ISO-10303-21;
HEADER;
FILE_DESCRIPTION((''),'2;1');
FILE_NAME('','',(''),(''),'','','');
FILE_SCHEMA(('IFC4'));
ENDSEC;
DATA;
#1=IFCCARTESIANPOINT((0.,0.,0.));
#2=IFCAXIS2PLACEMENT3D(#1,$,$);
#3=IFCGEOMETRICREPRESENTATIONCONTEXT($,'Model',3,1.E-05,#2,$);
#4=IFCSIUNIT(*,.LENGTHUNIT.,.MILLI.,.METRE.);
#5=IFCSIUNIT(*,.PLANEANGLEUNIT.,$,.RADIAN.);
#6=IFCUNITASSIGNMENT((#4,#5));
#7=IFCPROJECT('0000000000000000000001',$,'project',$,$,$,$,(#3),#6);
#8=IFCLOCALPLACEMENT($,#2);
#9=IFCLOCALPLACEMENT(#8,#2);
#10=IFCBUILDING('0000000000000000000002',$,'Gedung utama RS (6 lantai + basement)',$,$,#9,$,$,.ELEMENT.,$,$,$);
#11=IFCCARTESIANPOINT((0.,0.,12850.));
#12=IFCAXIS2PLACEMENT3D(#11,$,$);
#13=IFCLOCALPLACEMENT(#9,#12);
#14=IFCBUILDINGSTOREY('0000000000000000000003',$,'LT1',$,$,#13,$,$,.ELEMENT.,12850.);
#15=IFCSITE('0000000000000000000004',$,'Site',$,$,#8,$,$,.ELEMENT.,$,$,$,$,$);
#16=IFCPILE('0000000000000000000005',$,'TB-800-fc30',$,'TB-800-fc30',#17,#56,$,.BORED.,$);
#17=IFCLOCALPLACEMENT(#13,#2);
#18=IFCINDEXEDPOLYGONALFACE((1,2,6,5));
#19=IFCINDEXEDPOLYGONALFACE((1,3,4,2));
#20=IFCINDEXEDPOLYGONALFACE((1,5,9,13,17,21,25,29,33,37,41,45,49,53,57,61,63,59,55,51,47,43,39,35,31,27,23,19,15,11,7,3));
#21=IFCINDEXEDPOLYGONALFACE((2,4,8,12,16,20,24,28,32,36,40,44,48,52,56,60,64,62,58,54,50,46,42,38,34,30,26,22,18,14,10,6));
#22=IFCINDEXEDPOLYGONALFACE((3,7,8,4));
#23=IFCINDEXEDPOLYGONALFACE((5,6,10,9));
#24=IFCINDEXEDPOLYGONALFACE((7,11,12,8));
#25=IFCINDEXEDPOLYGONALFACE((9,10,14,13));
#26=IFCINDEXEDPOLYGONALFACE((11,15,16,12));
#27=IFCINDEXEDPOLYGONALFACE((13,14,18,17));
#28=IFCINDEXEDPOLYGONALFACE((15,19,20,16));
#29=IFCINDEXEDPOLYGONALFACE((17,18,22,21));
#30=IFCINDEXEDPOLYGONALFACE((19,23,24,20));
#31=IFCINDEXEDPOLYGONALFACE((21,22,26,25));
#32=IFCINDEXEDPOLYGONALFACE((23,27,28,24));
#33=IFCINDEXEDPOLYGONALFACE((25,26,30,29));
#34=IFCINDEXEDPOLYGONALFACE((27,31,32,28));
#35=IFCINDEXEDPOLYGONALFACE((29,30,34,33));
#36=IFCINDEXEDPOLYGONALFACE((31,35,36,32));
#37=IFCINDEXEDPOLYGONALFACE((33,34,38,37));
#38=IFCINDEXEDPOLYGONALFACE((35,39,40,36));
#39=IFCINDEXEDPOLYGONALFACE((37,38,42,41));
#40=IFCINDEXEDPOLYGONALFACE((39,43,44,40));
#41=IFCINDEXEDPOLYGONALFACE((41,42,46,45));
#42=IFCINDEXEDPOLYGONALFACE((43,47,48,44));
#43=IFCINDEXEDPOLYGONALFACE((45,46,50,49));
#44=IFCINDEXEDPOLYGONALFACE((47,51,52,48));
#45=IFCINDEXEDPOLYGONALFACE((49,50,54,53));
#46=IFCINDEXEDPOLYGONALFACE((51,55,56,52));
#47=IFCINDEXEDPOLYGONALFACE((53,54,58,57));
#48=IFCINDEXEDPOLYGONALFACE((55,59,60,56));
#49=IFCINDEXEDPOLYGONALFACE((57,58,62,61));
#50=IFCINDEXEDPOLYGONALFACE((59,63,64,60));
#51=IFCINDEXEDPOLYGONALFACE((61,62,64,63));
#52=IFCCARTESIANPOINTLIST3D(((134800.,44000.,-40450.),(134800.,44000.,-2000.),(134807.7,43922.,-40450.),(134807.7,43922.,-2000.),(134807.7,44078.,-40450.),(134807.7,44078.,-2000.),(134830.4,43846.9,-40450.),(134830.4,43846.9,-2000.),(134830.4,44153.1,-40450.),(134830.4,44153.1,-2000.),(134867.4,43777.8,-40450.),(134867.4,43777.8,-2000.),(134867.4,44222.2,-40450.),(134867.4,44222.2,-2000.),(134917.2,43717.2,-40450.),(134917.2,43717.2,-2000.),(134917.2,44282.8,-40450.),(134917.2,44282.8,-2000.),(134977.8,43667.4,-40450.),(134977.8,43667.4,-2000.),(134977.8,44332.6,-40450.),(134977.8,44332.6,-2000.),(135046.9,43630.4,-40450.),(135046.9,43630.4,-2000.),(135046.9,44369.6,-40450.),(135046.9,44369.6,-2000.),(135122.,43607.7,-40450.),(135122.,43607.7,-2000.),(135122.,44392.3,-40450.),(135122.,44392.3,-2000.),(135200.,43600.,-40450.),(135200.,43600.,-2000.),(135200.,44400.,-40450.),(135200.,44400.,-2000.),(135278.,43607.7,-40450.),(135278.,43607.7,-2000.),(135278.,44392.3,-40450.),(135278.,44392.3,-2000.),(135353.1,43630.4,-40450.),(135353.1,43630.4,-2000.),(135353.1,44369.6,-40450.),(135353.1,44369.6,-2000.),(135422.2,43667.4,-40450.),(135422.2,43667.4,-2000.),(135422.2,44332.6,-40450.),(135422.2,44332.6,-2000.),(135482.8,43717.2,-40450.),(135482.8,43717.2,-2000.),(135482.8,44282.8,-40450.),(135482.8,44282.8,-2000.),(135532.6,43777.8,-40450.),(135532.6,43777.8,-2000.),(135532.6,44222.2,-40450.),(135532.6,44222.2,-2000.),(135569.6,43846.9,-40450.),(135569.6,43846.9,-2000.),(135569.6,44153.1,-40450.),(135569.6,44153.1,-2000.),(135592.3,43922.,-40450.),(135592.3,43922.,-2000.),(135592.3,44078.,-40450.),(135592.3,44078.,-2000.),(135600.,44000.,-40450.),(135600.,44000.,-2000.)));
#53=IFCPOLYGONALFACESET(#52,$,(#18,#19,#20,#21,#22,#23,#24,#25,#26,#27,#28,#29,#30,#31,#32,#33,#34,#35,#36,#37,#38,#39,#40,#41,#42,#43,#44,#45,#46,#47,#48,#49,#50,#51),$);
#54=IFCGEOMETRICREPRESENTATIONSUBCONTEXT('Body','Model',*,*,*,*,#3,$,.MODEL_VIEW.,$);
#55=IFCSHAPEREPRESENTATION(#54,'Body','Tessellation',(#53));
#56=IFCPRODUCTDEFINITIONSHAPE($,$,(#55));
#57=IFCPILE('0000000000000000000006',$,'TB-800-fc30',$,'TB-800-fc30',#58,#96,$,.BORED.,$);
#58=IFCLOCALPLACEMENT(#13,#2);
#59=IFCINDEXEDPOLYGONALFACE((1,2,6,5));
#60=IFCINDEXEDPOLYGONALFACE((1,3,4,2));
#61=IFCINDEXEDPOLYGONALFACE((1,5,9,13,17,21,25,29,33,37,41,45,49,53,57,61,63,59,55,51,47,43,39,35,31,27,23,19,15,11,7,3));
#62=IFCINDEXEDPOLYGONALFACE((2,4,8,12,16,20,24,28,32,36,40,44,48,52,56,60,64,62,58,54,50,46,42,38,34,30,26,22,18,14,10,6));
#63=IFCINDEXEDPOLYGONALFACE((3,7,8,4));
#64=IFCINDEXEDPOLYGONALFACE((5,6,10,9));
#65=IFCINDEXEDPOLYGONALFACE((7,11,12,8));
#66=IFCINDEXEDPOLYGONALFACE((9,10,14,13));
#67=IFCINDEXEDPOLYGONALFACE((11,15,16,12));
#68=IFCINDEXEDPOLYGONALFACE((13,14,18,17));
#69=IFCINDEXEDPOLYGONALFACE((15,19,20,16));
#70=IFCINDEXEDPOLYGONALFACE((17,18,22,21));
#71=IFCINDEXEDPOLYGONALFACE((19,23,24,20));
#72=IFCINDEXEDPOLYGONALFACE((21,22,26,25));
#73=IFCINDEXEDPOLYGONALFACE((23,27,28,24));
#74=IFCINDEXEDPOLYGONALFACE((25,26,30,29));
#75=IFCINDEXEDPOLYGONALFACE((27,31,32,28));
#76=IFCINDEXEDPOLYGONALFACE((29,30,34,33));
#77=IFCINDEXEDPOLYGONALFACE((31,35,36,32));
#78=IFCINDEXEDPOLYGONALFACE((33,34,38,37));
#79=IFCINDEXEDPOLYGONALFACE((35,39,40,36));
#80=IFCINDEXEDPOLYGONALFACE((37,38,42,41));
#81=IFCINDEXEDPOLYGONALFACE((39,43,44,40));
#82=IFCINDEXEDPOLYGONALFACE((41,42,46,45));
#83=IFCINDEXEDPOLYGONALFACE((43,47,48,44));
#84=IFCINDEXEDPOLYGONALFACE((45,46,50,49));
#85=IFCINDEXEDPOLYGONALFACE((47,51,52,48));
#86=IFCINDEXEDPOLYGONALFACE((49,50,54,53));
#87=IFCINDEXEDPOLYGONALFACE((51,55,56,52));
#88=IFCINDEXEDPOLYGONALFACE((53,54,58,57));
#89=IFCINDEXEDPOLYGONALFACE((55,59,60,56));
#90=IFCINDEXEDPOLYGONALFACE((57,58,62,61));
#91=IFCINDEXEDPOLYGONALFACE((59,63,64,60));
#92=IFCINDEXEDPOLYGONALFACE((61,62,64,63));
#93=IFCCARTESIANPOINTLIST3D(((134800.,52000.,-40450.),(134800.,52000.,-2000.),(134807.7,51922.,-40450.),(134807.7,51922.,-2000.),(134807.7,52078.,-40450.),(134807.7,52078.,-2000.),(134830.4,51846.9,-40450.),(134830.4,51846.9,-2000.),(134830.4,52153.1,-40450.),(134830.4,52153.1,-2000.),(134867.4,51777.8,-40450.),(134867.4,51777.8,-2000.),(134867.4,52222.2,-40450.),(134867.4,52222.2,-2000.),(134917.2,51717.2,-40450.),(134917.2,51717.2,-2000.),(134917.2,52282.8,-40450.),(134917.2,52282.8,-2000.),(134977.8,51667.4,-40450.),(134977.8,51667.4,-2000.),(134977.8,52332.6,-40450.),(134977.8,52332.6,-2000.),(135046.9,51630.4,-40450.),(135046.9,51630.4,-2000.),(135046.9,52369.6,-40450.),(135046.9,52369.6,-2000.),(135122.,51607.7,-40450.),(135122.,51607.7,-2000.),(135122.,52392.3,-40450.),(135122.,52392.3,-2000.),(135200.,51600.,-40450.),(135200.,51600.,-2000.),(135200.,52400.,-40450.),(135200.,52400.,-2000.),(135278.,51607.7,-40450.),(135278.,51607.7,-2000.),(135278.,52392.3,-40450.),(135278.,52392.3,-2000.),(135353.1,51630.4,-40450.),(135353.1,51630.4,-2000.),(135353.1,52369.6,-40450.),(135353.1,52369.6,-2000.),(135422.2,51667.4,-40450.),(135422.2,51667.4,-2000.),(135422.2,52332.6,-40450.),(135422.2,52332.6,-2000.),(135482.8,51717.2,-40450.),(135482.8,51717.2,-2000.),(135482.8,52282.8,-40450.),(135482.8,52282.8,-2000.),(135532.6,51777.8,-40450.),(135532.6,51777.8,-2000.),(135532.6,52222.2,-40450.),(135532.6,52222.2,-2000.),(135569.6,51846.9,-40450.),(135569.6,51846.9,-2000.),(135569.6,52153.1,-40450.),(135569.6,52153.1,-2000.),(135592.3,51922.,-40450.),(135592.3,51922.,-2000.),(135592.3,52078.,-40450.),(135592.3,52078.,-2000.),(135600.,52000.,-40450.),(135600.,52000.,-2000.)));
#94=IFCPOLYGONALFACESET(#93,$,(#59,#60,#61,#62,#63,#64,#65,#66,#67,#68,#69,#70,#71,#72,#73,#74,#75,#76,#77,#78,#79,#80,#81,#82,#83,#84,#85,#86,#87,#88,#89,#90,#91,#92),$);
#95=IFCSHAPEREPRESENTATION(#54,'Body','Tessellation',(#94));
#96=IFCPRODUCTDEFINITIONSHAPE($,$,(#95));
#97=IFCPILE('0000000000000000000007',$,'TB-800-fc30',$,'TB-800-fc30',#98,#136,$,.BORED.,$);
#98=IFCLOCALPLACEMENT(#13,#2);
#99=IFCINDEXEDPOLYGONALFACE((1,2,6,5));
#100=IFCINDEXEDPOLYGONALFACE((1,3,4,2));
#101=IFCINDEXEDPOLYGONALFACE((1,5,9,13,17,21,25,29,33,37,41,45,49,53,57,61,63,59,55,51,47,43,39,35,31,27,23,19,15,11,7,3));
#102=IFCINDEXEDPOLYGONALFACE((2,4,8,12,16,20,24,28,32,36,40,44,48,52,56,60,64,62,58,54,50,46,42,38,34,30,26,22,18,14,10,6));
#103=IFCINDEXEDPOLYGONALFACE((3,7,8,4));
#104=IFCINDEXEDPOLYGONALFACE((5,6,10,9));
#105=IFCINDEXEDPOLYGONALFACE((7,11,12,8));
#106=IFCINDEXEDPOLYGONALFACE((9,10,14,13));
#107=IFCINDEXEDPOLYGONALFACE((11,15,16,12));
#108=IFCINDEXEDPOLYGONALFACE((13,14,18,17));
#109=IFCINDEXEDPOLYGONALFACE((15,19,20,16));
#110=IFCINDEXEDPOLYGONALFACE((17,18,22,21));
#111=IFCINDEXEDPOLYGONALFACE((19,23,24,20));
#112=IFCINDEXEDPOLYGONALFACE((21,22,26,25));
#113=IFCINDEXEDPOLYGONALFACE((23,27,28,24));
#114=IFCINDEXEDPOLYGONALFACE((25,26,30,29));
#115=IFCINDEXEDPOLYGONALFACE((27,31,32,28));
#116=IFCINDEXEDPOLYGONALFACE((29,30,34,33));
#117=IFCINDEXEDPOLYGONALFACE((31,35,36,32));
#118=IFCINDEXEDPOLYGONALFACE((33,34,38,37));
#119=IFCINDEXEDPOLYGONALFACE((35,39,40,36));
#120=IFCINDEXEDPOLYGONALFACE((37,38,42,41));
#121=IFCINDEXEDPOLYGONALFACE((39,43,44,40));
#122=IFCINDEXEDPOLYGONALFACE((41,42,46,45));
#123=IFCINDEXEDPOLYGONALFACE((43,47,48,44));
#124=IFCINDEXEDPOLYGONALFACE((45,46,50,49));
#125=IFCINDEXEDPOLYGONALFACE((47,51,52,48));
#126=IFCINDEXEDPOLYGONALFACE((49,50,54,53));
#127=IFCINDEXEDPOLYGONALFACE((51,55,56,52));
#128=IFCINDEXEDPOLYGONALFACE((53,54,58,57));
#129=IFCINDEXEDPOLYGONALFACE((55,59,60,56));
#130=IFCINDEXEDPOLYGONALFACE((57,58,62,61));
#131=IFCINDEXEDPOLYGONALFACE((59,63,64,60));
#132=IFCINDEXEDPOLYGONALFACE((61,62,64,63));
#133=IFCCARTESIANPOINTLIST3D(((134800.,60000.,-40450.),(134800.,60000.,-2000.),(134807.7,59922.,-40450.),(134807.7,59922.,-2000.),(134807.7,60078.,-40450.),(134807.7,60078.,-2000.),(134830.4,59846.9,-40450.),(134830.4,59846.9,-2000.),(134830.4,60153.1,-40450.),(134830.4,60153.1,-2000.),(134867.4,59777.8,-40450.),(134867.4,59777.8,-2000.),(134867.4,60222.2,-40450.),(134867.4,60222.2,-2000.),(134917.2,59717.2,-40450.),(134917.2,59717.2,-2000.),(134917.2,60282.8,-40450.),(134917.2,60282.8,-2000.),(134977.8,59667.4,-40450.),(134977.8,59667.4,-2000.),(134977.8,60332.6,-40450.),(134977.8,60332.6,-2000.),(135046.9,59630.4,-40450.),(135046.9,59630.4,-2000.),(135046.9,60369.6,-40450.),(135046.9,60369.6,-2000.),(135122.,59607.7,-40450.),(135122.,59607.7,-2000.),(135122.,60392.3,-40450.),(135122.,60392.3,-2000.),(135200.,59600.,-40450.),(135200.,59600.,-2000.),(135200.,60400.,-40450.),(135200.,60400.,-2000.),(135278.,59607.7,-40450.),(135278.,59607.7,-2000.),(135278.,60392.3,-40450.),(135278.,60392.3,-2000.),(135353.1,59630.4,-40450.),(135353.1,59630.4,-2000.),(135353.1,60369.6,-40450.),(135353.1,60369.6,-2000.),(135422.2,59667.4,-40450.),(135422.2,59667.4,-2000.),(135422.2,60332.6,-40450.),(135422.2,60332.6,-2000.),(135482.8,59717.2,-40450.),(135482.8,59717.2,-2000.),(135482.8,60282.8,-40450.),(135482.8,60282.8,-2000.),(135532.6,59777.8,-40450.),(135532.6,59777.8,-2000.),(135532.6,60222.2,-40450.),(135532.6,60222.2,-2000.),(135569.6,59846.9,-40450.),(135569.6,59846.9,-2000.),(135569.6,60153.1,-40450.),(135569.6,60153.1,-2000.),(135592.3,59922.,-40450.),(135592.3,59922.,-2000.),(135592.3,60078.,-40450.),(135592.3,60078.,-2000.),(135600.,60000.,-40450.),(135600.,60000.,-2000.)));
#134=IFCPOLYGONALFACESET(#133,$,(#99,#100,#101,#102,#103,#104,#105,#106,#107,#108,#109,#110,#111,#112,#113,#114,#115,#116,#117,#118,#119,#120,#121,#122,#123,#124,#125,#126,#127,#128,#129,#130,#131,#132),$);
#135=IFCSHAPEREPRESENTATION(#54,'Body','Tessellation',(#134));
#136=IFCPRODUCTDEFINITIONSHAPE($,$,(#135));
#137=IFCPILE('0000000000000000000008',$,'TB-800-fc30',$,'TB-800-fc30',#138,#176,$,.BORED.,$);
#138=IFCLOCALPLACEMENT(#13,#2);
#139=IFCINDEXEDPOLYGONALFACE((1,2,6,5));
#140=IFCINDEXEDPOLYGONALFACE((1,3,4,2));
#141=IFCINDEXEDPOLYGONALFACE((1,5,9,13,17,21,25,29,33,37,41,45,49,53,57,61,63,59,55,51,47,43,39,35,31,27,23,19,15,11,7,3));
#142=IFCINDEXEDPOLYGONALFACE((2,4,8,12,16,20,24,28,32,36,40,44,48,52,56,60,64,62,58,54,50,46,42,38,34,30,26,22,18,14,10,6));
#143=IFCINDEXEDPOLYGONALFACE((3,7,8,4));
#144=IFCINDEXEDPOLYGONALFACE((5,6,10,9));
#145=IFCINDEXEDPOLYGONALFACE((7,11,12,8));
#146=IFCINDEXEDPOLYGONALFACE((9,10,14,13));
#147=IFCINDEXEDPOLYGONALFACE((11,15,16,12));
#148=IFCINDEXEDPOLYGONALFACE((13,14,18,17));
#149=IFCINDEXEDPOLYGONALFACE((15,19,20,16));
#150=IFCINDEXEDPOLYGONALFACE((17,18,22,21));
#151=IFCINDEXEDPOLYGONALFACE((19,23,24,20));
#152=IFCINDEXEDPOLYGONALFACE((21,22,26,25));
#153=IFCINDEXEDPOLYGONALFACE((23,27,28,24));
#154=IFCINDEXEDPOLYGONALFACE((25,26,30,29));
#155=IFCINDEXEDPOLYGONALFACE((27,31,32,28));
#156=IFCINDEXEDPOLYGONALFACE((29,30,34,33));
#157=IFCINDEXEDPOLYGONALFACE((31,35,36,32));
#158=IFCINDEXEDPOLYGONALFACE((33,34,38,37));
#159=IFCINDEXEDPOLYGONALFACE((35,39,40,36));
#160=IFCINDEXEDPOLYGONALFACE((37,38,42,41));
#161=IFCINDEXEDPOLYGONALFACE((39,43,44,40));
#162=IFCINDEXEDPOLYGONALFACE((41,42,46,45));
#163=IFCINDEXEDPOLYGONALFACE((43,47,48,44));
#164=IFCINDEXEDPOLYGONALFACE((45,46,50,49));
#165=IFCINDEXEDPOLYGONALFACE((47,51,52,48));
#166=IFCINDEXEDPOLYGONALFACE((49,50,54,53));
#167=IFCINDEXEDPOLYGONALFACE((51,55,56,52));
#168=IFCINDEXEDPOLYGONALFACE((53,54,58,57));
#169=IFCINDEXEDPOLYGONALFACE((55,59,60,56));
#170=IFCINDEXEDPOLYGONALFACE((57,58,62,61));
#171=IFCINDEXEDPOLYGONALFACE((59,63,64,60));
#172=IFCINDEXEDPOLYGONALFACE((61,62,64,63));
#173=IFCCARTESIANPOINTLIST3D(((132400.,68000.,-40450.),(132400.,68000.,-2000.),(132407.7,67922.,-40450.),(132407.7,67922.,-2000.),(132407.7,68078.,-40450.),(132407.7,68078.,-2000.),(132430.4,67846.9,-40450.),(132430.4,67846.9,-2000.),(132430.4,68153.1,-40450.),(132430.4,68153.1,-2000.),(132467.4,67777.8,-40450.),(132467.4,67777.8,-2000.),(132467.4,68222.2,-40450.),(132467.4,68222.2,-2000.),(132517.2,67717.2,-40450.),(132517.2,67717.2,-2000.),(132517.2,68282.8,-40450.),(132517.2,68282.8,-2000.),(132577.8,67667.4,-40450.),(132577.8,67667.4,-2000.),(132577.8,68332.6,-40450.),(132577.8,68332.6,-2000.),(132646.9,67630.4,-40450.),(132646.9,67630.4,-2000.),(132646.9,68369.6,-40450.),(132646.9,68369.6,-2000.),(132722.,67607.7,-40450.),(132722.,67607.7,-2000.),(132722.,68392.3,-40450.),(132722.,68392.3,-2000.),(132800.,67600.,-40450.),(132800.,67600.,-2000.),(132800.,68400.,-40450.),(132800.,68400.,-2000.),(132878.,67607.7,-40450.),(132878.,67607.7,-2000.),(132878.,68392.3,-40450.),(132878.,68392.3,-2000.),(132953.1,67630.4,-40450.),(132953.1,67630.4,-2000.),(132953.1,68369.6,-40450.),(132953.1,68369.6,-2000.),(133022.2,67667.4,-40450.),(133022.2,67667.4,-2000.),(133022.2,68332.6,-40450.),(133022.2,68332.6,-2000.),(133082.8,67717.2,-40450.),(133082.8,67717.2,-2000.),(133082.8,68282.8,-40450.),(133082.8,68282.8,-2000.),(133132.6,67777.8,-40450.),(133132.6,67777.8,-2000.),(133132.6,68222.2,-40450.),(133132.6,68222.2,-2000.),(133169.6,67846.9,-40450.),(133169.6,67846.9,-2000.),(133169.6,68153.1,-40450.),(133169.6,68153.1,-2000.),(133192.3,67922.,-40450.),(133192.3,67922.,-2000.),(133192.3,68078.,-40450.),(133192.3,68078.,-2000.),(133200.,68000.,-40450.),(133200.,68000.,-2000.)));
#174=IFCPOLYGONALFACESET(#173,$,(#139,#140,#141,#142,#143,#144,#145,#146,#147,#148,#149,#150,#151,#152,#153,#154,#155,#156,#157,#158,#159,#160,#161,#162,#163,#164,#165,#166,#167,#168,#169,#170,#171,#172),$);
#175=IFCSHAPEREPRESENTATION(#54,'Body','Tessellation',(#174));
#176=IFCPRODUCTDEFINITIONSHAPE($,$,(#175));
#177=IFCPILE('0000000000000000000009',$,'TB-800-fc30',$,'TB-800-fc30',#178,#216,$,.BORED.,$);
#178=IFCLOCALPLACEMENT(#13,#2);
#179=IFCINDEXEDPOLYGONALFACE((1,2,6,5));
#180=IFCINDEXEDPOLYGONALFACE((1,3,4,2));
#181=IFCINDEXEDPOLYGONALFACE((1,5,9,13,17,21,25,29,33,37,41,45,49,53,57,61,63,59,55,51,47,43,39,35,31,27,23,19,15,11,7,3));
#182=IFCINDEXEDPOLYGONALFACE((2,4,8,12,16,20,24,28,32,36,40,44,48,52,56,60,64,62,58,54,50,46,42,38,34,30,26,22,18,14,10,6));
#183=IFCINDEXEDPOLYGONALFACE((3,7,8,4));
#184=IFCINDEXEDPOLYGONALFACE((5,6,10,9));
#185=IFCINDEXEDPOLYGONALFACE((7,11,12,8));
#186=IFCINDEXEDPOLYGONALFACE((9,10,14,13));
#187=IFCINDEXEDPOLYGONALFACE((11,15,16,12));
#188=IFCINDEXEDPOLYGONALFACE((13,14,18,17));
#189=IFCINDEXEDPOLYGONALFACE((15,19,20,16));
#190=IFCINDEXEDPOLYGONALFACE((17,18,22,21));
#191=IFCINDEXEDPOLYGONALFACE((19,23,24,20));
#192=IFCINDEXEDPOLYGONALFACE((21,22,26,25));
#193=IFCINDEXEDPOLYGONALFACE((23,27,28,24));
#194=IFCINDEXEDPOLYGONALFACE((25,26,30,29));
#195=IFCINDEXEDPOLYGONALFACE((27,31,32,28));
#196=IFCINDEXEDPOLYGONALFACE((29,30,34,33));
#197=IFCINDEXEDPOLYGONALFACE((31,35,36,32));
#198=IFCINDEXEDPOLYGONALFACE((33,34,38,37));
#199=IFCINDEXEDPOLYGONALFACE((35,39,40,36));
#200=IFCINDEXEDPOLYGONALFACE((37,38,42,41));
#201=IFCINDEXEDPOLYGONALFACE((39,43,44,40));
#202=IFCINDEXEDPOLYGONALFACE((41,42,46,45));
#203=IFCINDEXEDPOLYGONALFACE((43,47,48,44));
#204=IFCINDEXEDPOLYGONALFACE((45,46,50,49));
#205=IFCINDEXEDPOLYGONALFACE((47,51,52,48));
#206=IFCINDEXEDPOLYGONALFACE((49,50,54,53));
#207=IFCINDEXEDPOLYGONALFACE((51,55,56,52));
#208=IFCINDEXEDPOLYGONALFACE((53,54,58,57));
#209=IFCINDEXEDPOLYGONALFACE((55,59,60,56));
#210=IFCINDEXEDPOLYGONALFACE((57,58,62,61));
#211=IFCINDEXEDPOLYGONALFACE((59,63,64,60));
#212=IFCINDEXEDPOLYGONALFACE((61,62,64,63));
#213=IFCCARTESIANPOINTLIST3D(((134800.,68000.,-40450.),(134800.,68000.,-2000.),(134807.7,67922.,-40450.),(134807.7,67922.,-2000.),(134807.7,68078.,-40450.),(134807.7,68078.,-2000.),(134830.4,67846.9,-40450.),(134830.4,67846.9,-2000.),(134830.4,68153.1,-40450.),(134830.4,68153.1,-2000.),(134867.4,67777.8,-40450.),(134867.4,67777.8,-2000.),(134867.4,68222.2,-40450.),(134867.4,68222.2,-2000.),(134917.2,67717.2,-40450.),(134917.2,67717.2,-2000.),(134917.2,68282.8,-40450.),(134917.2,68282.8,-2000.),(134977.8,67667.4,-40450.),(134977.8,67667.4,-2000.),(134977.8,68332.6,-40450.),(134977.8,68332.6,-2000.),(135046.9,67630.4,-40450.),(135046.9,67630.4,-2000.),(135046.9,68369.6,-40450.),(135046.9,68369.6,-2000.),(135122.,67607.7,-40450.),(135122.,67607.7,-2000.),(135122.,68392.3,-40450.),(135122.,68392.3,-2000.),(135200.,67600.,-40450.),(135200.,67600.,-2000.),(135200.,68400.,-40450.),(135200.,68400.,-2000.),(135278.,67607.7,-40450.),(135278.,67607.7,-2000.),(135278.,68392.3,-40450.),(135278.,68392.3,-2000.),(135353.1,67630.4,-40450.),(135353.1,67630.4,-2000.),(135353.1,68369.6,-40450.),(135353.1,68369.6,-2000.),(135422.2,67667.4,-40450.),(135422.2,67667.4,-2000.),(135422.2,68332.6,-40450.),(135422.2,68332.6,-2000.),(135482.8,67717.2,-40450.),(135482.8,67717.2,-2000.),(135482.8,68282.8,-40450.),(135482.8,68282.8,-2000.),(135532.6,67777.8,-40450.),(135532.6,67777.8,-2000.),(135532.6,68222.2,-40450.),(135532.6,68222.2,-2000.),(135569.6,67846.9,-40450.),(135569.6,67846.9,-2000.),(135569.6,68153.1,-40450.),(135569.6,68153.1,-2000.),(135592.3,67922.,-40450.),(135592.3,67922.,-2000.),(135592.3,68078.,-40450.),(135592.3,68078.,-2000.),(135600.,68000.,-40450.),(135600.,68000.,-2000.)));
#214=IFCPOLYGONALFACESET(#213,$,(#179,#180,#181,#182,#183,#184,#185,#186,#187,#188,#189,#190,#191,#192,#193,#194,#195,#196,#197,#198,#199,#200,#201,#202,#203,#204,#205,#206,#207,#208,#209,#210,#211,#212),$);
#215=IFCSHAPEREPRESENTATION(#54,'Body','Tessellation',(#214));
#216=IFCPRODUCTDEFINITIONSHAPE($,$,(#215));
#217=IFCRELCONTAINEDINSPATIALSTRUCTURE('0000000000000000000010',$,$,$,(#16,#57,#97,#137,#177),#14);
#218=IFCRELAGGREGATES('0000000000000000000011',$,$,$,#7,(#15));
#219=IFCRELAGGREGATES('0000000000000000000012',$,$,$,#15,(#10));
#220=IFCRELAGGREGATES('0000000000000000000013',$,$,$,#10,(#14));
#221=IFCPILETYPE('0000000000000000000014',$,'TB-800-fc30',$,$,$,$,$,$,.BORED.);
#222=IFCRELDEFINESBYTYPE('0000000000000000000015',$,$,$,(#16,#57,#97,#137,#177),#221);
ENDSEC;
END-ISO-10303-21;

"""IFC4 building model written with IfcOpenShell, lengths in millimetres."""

from ifc_helpers import new_model, si_unit, frame, origin, origin_2d, place, context, subcontext, project, spatial, circle, extrude, material_profile, profile_set, profile_usage, type_object, element, save


model = new_model("IFC4")

# Units and contexts
model_context = context("Model", 3, precision=1e-05, world=origin())
body_context = subcontext(model_context, "Body", "Model", "MODEL_VIEW")
ifc_project = project(units=[si_unit("LENGTHUNIT", "METRE", prefix="MILLI"), si_unit("PLANEANGLEUNIT", "RADIAN")], contexts=[model_context])

# Site, building, storey
site_placement = place(None, origin())
site = spatial("IfcSite", under=ifc_project, at=site_placement, Name="Site", CompositionType="ELEMENT")
building_placement = place(site_placement, origin())
building = spatial("IfcBuilding", under=site, at=building_placement, Name="Gedung utama RS (6 lantai + basement)", CompositionType="ELEMENT")
storey_placement = place(building_placement, frame((0.0, 0.0, 12850.0)))
storey = spatial("IfcBuildingStorey", under=building, at=storey_placement, Name="LT1", CompositionType="ELEMENT", Elevation=12850.0)

# Piles
ifc_material_profile_1 = material_profile(None, circle(Radius=400.0, at=origin_2d()), Name="TB-800-fc30")
ifc_profile_set_1 = profile_set([ifc_material_profile_1], Name="TB-800-fc30")
ifc_profile_usage_1 = profile_usage(ifc_profile_set_1, cardinal=5)
pile_type = type_object("IfcPileType", Name="TB-800-fc30", PredefinedType="BORED", material=ifc_profile_set_1)
for number, where, z_axis, x_axis, name in (
    (1, (135200.0, 44000.0, -40450.0), (0.0, 0.0, 1.0), (1.0, 0.0, 0.0), "TB-800-fc30"),
    (2, (135200.0, 52000.0, -40450.0), (0.0, 0.0, 1.0), (1.0, 0.0, 0.0), "TB-800-fc30"),
    (3, (135200.0, 60000.0, -40450.0), (0.0, 0.0, 1.0), (1.0, 0.0, 0.0), "TB-800-fc30"),
    (4, (132800.0, 68000.0, -40450.0), (0.0, 0.0, 1.0), (1.0, 0.0, 0.0), "TB-800-fc30"),
    (5, (135200.0, 68000.0, -40450.0), (0.0, 0.0, 1.0), (1.0, 0.0, 0.0), "TB-800-fc30"),
):
    element("IfcPile", number, at=place(storey_placement, frame(where, z_axis=z_axis, x_axis=x_axis)), inside=storey, type_object=pile_type, material=ifc_profile_usage_1, Name=name, ObjectType="TB-800-fc30", PredefinedType="BORED", context=body_context, shape_type="SweptSolid", body=[
        extrude(circle(Radius=400.0, at=origin_2d()), origin(), (0.0, 0.0, 1.0), 38450.0),
    ])

save(model, "model.ifc")
